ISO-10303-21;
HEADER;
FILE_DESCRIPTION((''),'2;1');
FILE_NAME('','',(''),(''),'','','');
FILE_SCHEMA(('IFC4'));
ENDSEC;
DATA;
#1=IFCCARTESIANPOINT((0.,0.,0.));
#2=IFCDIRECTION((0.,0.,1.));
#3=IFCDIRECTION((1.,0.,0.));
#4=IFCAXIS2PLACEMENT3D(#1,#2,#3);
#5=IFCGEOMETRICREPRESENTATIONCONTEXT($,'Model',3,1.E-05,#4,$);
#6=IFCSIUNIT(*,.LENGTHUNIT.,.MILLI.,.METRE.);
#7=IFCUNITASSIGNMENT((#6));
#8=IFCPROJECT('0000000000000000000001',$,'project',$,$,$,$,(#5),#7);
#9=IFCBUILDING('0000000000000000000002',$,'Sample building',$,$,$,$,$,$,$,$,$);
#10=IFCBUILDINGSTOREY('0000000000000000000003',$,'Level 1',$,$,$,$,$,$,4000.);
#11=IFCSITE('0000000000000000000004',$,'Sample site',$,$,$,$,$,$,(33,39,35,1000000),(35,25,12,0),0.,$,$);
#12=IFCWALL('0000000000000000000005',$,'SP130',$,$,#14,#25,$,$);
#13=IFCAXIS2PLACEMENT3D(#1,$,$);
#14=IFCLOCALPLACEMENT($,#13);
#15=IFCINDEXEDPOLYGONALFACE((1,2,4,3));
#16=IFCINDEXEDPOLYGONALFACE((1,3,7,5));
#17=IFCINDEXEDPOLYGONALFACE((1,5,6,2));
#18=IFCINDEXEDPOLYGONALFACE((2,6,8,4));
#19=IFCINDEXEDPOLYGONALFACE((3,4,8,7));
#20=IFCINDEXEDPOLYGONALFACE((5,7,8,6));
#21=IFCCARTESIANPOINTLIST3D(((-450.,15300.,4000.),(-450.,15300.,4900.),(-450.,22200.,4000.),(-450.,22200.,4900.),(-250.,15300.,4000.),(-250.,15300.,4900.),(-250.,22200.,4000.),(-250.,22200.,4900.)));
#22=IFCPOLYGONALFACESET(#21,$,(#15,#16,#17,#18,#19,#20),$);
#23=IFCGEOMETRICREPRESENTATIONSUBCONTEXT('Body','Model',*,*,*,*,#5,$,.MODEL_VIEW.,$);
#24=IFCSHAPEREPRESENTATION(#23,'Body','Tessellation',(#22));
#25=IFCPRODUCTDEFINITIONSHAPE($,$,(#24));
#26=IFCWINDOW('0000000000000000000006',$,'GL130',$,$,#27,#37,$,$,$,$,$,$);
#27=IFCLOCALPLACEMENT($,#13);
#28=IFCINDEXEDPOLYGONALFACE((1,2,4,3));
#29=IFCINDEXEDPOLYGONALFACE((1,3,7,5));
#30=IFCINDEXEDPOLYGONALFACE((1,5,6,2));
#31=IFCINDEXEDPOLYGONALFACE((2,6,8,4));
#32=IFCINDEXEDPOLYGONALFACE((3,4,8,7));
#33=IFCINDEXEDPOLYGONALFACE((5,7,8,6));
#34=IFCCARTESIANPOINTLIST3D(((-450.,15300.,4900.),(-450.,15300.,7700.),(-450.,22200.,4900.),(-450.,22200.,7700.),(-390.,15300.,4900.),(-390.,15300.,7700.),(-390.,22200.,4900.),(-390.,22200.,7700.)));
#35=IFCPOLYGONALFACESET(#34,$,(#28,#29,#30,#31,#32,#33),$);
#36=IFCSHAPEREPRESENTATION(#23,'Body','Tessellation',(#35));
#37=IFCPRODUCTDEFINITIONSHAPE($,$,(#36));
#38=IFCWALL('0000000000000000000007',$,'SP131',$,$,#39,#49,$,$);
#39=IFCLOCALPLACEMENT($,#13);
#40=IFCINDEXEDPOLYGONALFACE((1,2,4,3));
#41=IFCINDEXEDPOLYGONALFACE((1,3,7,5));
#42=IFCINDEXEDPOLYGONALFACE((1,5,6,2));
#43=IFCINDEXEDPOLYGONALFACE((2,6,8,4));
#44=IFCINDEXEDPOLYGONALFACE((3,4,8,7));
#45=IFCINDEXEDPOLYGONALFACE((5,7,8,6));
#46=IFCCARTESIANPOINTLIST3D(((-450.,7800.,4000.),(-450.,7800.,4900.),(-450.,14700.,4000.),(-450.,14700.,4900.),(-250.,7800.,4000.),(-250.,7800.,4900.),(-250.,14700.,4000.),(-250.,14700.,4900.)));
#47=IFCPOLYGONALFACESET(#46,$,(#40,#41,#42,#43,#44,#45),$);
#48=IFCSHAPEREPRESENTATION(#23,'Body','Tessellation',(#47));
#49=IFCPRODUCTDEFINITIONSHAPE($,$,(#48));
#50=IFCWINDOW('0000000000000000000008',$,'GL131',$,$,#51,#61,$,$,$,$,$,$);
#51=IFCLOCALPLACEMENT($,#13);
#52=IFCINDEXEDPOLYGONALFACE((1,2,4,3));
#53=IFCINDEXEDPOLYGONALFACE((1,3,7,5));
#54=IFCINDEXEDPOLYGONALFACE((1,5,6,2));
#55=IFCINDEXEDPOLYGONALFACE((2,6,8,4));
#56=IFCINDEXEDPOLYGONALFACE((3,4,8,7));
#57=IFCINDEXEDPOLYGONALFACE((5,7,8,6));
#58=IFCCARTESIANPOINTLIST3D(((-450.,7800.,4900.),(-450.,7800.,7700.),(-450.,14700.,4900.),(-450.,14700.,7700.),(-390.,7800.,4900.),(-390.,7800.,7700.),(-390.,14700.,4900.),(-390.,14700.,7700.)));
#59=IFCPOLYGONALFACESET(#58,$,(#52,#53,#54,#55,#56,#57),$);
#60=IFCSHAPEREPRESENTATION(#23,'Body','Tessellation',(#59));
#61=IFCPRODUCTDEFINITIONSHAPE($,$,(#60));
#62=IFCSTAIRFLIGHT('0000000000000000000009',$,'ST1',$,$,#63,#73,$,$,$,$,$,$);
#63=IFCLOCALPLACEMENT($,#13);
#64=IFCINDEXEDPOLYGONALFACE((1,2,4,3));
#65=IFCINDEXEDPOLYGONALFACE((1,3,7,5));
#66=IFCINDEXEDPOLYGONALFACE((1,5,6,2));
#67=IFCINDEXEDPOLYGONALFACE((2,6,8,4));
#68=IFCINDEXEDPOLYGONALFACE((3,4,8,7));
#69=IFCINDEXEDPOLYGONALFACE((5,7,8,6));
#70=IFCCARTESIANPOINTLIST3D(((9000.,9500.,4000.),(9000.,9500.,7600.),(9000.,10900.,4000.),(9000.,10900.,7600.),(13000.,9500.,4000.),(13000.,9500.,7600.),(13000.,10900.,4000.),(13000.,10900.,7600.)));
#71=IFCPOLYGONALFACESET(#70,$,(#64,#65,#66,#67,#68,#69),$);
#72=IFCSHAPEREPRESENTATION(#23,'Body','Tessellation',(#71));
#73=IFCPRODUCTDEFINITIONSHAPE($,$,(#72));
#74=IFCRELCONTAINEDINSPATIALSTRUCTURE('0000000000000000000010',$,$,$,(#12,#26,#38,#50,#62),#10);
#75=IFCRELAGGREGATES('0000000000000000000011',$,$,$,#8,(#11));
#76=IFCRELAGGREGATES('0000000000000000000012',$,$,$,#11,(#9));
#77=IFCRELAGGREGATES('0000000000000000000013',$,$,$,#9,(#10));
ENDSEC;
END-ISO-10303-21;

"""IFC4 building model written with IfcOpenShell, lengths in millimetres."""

from ifc_helpers import new_model, si_unit, frame, origin_with_axes, place, context, subcontext, project, spatial, indexed_curve, outline, extrude, element, save


model = new_model("IFC4")

# Units and contexts
model_context = context("Model", 3, precision=1e-05, world=origin_with_axes())
body_context = subcontext(model_context, "Body", "Model", "MODEL_VIEW")
ifc_project = project(units=[si_unit("LENGTHUNIT", "METRE", prefix="MILLI")], contexts=[model_context])

# Site, building, storey
site = spatial("IfcSite", under=ifc_project, Name="Sample site", RefLatitude=(33, 39, 35, 1000000), RefLongitude=(35, 25, 12, 0), RefElevation=0.0)
building = spatial("IfcBuilding", under=site, Name="Sample building")
storey = spatial("IfcBuildingStorey", under=building, Name="Level 1", Elevation=4000.0)

# Wall
wall_1_placement = place(None, frame((-450.0, 22200.0, 4000.0), z_axis=(0.0, 0.0, 1.0), x_axis=(0.0, -1.0, 0.0)))
element("IfcWall", 1, at=wall_1_placement, inside=storey, Name="SP130", context=body_context, shape_type="SweptSolid", body=[
    extrude(outline(indexed_curve([(0.0, 0.0), (0.0, 200.0), (6900.0, 200.0), (6900.0, 0.0), (0.0, 0.0)], self_intersect=False)), origin_with_axes(), (0.0, 0.0, 1.0), 900.0),
])

# Window
window_1_placement = place(None, frame((-450.0, 22200.0, 4900.0), z_axis=(0.0, 0.0, 1.0), x_axis=(0.0, -1.0, 0.0)))
element("IfcWindow", 2, at=window_1_placement, inside=storey, Name="GL130", context=body_context, shape_type="SweptSolid", body=[
    extrude(outline(indexed_curve([(0.0, 0.0), (0.0, 60.0), (6900.0, 60.0), (6900.0, 0.0), (0.0, 0.0)], self_intersect=False)), origin_with_axes(), (0.0, 0.0, 1.0), 2800.0),
])

# Wall
wall_2_placement = place(None, frame((-450.0, 14700.0, 4000.0), z_axis=(0.0, 0.0, 1.0), x_axis=(0.0, -1.0, 0.0)))
element("IfcWall", 3, at=wall_2_placement, inside=storey, Name="SP131", context=body_context, shape_type="SweptSolid", body=[
    extrude(outline(indexed_curve([(0.0, 0.0), (0.0, 200.0), (6900.0, 200.0), (6900.0, 0.0), (0.0, 0.0)], self_intersect=False)), origin_with_axes(), (0.0, 0.0, 1.0), 900.0),
])

# Window
window_2_placement = place(None, frame((-450.0, 14700.0, 4900.0), z_axis=(0.0, 0.0, 1.0), x_axis=(0.0, -1.0, 0.0)))
element("IfcWindow", 4, at=window_2_placement, inside=storey, Name="GL131", context=body_context, shape_type="SweptSolid", body=[
    extrude(outline(indexed_curve([(0.0, 0.0), (0.0, 60.0), (6900.0, 60.0), (6900.0, 0.0), (0.0, 0.0)], self_intersect=False)), origin_with_axes(), (0.0, 0.0, 1.0), 2800.0),
])

# Stair flight
stair_flight_placement = place(None, frame((9000.0, 9500.0, 4000.0), z_axis=(0.0, 0.0, 1.0), x_axis=(1.0, 0.0, 0.0)))
element("IfcStairFlight", 5, at=stair_flight_placement, inside=storey, Name="ST1", context=body_context, shape_type="SweptSolid", body=[
    extrude(outline(indexed_curve([(0.0, 0.0), (0.0, 1400.0), (4000.0, 1400.0), (4000.0, 0.0), (0.0, 0.0)], self_intersect=False)), origin_with_axes(), (0.0, 0.0, 1.0), 3600.0),
])

save(model, "model.ifc")
